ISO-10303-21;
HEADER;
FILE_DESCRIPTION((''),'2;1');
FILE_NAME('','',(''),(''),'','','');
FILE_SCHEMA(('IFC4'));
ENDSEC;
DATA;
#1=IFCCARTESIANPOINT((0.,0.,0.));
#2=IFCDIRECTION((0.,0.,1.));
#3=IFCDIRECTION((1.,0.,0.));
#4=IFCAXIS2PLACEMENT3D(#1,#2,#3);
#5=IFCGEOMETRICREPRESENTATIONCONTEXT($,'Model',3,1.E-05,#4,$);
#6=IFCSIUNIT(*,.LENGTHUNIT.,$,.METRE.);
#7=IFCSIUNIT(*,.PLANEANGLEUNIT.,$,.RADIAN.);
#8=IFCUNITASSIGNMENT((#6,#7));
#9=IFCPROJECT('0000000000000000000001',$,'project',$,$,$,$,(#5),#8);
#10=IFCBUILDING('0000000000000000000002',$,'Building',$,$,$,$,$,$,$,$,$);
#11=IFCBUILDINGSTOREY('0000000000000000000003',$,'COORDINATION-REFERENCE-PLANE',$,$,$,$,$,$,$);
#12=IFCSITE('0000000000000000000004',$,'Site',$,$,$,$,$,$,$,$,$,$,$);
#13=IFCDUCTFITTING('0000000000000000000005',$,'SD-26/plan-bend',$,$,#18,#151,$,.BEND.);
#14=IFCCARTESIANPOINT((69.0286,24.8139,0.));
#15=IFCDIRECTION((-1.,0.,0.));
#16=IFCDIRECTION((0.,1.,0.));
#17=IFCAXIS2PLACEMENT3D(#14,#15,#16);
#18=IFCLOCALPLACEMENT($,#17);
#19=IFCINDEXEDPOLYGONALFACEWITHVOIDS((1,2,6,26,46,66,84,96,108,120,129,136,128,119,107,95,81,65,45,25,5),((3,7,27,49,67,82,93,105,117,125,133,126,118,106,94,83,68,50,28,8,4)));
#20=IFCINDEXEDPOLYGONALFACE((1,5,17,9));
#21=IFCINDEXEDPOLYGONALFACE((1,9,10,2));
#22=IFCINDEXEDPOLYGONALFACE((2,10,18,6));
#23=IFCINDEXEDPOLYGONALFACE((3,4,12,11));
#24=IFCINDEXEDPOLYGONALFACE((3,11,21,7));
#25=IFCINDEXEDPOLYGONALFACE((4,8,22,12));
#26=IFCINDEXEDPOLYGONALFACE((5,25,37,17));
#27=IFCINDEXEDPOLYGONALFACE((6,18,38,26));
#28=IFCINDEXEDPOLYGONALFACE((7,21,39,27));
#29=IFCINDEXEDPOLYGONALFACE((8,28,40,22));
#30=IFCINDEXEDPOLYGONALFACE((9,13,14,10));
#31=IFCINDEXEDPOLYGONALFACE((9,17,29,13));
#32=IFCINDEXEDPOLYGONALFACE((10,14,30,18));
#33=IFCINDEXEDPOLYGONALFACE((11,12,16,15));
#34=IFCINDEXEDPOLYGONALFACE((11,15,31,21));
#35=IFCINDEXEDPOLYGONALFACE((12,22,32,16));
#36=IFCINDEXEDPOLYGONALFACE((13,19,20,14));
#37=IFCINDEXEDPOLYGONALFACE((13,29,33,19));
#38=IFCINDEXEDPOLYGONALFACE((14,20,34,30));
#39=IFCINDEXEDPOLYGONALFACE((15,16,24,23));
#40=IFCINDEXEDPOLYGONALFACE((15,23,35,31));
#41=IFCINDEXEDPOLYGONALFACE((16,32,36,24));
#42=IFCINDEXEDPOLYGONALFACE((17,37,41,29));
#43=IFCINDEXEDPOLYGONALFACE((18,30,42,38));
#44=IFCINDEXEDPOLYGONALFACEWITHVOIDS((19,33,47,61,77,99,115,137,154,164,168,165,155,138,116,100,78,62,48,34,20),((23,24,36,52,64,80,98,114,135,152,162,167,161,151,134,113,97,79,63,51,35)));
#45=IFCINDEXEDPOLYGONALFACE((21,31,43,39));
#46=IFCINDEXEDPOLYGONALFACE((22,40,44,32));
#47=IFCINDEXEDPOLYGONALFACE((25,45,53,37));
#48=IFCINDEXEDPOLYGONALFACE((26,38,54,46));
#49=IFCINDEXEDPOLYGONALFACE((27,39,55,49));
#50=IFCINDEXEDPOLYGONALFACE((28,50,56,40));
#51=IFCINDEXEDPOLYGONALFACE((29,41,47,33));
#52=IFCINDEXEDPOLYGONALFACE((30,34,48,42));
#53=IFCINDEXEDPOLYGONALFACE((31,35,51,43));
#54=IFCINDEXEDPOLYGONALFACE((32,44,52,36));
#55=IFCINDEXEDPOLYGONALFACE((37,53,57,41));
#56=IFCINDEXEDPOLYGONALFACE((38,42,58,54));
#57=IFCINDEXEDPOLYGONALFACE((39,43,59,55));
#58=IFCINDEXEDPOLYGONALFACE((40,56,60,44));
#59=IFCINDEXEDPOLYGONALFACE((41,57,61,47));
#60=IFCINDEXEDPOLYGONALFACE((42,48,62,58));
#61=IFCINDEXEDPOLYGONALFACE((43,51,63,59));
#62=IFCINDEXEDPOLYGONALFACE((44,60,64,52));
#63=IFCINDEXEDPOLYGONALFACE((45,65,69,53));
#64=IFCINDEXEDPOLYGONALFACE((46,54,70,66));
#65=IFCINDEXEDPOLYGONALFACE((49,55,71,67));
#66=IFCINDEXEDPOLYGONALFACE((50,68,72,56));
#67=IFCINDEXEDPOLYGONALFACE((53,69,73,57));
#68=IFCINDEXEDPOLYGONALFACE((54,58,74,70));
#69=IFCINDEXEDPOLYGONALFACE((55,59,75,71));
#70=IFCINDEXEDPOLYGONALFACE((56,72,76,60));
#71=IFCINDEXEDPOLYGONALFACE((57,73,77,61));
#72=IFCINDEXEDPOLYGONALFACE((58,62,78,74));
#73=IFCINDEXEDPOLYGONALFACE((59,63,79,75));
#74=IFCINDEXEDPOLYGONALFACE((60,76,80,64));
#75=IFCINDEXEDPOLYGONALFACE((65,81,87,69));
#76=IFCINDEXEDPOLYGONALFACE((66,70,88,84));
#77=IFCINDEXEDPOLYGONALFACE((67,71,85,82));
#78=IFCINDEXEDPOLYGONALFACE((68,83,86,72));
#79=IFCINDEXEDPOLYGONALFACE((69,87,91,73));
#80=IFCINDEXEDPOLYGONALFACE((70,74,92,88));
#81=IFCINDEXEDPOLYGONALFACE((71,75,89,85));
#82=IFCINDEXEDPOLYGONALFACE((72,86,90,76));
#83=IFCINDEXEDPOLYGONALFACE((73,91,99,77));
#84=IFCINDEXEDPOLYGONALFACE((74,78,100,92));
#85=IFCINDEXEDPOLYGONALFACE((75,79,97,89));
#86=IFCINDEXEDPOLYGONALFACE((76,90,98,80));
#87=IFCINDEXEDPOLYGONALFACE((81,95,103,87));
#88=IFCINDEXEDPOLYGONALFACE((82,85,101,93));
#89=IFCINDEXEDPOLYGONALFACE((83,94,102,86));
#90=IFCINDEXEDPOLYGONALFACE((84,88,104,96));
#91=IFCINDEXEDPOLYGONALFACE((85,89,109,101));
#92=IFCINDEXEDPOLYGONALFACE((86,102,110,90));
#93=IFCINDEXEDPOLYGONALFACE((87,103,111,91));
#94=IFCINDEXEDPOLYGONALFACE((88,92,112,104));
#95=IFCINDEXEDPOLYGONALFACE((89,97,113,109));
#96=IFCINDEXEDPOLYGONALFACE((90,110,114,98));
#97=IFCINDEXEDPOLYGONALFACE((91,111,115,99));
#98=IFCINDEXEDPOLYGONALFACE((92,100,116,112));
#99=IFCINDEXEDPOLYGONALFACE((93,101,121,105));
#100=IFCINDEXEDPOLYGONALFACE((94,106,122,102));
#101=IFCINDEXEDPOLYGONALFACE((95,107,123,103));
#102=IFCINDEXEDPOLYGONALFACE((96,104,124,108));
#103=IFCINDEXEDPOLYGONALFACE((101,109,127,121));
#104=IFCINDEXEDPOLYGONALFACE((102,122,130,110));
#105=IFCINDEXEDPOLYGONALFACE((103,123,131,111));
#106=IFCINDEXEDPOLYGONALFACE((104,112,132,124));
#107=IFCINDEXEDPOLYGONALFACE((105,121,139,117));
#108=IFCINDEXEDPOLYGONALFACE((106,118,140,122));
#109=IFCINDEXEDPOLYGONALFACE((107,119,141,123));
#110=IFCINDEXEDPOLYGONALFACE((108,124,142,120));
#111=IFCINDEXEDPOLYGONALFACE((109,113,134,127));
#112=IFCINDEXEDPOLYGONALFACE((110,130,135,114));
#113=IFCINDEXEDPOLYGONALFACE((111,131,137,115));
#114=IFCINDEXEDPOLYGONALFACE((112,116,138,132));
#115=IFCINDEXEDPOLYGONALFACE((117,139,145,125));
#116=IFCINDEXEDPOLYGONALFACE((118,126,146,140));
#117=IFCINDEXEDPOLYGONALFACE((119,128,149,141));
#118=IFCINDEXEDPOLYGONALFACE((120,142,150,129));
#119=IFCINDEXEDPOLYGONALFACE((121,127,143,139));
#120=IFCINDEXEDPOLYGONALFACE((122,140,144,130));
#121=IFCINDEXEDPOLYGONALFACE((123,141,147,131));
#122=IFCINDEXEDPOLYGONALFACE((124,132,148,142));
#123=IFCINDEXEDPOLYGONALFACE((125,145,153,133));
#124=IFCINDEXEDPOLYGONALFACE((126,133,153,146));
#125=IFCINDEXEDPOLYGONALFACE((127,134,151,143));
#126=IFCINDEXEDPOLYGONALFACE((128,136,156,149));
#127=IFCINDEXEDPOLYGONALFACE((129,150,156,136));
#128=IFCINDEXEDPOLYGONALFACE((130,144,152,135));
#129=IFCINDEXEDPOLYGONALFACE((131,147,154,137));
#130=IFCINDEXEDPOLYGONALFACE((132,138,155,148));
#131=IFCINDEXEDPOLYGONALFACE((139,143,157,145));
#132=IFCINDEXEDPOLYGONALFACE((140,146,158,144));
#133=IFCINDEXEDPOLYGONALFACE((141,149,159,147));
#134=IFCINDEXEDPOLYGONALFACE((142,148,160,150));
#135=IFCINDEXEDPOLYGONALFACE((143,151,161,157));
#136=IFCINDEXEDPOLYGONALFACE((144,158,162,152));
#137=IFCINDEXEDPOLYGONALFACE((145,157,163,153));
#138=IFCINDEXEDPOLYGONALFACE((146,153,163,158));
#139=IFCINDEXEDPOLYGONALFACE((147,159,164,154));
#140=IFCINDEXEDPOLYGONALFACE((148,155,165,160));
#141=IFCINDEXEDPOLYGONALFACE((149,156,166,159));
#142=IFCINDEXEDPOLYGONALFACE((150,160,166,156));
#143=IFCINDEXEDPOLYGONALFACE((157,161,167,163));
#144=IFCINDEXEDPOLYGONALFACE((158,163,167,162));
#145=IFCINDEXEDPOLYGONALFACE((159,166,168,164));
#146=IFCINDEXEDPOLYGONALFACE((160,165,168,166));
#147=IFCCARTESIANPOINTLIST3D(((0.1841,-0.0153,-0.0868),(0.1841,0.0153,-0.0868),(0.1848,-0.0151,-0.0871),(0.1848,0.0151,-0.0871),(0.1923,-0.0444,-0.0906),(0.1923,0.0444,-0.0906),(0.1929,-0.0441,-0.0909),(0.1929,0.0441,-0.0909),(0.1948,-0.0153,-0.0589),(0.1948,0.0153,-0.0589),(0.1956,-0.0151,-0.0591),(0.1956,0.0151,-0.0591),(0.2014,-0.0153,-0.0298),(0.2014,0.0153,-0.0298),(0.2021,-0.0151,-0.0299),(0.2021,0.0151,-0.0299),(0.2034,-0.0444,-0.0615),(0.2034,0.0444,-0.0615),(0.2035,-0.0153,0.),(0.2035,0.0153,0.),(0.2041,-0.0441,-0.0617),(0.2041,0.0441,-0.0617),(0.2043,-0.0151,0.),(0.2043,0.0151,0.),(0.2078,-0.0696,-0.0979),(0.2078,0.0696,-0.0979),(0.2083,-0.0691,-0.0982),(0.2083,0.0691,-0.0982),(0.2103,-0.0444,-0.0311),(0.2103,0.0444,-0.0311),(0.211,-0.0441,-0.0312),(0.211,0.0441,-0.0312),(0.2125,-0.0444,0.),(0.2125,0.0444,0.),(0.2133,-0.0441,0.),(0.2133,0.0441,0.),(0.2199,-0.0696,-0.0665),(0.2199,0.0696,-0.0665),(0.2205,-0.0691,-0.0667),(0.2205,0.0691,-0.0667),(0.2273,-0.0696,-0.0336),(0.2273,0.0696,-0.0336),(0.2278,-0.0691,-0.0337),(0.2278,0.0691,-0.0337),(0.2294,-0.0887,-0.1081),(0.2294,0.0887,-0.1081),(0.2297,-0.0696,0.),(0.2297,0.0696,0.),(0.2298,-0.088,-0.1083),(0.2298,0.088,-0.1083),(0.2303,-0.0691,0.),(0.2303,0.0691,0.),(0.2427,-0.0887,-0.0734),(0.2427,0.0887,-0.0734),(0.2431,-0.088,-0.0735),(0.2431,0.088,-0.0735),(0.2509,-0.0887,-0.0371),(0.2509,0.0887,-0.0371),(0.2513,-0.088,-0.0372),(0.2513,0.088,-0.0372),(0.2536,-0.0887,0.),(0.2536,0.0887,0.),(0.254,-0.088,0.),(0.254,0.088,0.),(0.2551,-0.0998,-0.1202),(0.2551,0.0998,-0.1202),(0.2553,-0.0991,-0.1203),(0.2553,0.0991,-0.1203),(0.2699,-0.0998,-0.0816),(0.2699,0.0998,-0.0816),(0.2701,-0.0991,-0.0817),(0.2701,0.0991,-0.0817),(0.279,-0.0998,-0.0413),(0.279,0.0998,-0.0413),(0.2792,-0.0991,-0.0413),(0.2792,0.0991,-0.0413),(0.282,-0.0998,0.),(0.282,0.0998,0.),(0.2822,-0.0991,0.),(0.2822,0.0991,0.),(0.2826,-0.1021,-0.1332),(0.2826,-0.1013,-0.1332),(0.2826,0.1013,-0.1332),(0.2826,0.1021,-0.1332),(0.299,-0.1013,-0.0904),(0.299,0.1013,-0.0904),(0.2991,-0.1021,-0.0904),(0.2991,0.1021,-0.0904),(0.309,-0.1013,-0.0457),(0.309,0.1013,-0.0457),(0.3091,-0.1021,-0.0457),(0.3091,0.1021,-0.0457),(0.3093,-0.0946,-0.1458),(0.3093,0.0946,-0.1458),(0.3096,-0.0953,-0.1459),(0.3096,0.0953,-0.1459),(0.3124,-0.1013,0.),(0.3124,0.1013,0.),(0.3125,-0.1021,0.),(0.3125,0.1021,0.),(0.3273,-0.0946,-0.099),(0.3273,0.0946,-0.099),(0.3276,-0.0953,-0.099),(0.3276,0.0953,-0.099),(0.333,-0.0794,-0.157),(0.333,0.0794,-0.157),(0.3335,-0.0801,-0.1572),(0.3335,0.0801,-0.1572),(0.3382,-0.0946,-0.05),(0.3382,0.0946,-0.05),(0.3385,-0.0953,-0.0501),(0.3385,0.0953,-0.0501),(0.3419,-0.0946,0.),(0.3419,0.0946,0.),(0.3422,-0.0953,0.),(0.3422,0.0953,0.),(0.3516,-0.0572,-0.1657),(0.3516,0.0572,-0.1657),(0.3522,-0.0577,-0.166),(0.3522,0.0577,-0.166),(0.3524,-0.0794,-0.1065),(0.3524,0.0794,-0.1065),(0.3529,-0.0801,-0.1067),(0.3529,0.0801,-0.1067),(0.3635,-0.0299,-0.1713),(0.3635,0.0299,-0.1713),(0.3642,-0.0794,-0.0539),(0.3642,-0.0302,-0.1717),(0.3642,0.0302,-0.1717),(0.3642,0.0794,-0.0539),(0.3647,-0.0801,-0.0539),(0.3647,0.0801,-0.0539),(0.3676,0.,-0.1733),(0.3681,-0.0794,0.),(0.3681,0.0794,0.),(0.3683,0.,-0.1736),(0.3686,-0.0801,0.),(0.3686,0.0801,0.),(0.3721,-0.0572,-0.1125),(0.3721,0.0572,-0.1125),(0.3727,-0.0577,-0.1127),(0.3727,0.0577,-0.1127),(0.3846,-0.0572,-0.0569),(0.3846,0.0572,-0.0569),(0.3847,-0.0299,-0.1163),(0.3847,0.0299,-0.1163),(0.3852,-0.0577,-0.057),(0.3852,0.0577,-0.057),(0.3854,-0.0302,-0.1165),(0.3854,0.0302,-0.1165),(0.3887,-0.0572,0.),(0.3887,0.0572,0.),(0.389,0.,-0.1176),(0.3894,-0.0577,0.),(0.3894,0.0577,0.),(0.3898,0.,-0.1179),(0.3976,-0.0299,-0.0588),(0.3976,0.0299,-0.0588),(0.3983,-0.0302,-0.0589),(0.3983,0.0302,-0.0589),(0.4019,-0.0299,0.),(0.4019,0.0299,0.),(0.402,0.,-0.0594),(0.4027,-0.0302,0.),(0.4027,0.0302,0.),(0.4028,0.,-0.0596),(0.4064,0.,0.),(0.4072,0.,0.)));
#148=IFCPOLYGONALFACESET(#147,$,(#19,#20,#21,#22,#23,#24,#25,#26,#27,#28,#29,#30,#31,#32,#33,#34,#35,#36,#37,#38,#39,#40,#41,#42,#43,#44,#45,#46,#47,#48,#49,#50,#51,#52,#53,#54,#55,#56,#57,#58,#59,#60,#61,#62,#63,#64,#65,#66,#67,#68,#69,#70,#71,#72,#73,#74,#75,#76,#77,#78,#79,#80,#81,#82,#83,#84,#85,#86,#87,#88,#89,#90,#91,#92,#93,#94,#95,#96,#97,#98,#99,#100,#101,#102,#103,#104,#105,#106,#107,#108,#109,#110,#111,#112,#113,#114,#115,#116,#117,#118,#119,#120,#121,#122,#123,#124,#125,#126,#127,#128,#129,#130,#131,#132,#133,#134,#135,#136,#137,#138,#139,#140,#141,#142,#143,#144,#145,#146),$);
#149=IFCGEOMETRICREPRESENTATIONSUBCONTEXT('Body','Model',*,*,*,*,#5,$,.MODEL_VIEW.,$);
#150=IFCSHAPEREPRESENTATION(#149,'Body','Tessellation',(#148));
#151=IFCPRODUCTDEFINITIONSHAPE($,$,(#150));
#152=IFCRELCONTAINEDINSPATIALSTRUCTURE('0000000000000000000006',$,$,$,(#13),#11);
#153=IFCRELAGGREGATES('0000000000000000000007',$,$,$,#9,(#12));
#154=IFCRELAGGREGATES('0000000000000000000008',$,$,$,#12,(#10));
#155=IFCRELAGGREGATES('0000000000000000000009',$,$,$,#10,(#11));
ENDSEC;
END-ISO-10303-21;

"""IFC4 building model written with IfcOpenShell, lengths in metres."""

from ifc_helpers import new_model, entity, si_unit, frame, origin_with_axes, place, context, subcontext, project, spatial, element, save


model = new_model("IFC4")

# Units and contexts
model_context = context("Model", 3, precision=1e-05, world=origin_with_axes())
body_context_1 = subcontext(model_context, "Body", "Model", "MODEL_VIEW")
ifc_project = project(units=[si_unit("LENGTHUNIT", "METRE"), si_unit("PLANEANGLEUNIT", "RADIAN")], contexts=[model_context])

# Site, building, storey
site = spatial("IfcSite", under=ifc_project, Name="Site")
building = spatial("IfcBuilding", under=site, Name="Building")
storey = spatial("IfcBuildingStorey", under=building, Name="COORDINATION-REFERENCE-PLANE")

# Duct fitting
duct_fitting_1_placement = place(None, frame((69.0286, 24.8139, 0.0), z_axis=(-1.0, 0.0, 0.0), x_axis=(0.0, 1.0, 0.0)))
element("IfcDuctFitting", 1, at=duct_fitting_1_placement, inside=storey, Name="SD-26/plan-bend", PredefinedType="BEND", context=body_context_1, shape_type="SweptSolid", body=[
    entity("IfcRevolvedAreaSolid", entity("IfcCircleHollowProfileDef", "AREA", None, entity("IfcAxis2Placement2D", entity("IfcCartesianPoint", [0.3048, 0.0])), 0.1024, 0.0008), entity("IfcAxis2Placement3D", entity("IfcCartesianPoint", [0.0, 0.0, 0.0]), entity("IfcDirection", [0.0, 0.0, 1.0]), entity("IfcDirection", [1.0, 0.0, 0.0])), entity("IfcAxis1Placement", entity("IfcCartesianPoint", [0.0, 0.0, 0.0]), entity("IfcDirection", [0.0, 1.0, 0.0])), 0.440428),
])

save(model, "model.ifc")
